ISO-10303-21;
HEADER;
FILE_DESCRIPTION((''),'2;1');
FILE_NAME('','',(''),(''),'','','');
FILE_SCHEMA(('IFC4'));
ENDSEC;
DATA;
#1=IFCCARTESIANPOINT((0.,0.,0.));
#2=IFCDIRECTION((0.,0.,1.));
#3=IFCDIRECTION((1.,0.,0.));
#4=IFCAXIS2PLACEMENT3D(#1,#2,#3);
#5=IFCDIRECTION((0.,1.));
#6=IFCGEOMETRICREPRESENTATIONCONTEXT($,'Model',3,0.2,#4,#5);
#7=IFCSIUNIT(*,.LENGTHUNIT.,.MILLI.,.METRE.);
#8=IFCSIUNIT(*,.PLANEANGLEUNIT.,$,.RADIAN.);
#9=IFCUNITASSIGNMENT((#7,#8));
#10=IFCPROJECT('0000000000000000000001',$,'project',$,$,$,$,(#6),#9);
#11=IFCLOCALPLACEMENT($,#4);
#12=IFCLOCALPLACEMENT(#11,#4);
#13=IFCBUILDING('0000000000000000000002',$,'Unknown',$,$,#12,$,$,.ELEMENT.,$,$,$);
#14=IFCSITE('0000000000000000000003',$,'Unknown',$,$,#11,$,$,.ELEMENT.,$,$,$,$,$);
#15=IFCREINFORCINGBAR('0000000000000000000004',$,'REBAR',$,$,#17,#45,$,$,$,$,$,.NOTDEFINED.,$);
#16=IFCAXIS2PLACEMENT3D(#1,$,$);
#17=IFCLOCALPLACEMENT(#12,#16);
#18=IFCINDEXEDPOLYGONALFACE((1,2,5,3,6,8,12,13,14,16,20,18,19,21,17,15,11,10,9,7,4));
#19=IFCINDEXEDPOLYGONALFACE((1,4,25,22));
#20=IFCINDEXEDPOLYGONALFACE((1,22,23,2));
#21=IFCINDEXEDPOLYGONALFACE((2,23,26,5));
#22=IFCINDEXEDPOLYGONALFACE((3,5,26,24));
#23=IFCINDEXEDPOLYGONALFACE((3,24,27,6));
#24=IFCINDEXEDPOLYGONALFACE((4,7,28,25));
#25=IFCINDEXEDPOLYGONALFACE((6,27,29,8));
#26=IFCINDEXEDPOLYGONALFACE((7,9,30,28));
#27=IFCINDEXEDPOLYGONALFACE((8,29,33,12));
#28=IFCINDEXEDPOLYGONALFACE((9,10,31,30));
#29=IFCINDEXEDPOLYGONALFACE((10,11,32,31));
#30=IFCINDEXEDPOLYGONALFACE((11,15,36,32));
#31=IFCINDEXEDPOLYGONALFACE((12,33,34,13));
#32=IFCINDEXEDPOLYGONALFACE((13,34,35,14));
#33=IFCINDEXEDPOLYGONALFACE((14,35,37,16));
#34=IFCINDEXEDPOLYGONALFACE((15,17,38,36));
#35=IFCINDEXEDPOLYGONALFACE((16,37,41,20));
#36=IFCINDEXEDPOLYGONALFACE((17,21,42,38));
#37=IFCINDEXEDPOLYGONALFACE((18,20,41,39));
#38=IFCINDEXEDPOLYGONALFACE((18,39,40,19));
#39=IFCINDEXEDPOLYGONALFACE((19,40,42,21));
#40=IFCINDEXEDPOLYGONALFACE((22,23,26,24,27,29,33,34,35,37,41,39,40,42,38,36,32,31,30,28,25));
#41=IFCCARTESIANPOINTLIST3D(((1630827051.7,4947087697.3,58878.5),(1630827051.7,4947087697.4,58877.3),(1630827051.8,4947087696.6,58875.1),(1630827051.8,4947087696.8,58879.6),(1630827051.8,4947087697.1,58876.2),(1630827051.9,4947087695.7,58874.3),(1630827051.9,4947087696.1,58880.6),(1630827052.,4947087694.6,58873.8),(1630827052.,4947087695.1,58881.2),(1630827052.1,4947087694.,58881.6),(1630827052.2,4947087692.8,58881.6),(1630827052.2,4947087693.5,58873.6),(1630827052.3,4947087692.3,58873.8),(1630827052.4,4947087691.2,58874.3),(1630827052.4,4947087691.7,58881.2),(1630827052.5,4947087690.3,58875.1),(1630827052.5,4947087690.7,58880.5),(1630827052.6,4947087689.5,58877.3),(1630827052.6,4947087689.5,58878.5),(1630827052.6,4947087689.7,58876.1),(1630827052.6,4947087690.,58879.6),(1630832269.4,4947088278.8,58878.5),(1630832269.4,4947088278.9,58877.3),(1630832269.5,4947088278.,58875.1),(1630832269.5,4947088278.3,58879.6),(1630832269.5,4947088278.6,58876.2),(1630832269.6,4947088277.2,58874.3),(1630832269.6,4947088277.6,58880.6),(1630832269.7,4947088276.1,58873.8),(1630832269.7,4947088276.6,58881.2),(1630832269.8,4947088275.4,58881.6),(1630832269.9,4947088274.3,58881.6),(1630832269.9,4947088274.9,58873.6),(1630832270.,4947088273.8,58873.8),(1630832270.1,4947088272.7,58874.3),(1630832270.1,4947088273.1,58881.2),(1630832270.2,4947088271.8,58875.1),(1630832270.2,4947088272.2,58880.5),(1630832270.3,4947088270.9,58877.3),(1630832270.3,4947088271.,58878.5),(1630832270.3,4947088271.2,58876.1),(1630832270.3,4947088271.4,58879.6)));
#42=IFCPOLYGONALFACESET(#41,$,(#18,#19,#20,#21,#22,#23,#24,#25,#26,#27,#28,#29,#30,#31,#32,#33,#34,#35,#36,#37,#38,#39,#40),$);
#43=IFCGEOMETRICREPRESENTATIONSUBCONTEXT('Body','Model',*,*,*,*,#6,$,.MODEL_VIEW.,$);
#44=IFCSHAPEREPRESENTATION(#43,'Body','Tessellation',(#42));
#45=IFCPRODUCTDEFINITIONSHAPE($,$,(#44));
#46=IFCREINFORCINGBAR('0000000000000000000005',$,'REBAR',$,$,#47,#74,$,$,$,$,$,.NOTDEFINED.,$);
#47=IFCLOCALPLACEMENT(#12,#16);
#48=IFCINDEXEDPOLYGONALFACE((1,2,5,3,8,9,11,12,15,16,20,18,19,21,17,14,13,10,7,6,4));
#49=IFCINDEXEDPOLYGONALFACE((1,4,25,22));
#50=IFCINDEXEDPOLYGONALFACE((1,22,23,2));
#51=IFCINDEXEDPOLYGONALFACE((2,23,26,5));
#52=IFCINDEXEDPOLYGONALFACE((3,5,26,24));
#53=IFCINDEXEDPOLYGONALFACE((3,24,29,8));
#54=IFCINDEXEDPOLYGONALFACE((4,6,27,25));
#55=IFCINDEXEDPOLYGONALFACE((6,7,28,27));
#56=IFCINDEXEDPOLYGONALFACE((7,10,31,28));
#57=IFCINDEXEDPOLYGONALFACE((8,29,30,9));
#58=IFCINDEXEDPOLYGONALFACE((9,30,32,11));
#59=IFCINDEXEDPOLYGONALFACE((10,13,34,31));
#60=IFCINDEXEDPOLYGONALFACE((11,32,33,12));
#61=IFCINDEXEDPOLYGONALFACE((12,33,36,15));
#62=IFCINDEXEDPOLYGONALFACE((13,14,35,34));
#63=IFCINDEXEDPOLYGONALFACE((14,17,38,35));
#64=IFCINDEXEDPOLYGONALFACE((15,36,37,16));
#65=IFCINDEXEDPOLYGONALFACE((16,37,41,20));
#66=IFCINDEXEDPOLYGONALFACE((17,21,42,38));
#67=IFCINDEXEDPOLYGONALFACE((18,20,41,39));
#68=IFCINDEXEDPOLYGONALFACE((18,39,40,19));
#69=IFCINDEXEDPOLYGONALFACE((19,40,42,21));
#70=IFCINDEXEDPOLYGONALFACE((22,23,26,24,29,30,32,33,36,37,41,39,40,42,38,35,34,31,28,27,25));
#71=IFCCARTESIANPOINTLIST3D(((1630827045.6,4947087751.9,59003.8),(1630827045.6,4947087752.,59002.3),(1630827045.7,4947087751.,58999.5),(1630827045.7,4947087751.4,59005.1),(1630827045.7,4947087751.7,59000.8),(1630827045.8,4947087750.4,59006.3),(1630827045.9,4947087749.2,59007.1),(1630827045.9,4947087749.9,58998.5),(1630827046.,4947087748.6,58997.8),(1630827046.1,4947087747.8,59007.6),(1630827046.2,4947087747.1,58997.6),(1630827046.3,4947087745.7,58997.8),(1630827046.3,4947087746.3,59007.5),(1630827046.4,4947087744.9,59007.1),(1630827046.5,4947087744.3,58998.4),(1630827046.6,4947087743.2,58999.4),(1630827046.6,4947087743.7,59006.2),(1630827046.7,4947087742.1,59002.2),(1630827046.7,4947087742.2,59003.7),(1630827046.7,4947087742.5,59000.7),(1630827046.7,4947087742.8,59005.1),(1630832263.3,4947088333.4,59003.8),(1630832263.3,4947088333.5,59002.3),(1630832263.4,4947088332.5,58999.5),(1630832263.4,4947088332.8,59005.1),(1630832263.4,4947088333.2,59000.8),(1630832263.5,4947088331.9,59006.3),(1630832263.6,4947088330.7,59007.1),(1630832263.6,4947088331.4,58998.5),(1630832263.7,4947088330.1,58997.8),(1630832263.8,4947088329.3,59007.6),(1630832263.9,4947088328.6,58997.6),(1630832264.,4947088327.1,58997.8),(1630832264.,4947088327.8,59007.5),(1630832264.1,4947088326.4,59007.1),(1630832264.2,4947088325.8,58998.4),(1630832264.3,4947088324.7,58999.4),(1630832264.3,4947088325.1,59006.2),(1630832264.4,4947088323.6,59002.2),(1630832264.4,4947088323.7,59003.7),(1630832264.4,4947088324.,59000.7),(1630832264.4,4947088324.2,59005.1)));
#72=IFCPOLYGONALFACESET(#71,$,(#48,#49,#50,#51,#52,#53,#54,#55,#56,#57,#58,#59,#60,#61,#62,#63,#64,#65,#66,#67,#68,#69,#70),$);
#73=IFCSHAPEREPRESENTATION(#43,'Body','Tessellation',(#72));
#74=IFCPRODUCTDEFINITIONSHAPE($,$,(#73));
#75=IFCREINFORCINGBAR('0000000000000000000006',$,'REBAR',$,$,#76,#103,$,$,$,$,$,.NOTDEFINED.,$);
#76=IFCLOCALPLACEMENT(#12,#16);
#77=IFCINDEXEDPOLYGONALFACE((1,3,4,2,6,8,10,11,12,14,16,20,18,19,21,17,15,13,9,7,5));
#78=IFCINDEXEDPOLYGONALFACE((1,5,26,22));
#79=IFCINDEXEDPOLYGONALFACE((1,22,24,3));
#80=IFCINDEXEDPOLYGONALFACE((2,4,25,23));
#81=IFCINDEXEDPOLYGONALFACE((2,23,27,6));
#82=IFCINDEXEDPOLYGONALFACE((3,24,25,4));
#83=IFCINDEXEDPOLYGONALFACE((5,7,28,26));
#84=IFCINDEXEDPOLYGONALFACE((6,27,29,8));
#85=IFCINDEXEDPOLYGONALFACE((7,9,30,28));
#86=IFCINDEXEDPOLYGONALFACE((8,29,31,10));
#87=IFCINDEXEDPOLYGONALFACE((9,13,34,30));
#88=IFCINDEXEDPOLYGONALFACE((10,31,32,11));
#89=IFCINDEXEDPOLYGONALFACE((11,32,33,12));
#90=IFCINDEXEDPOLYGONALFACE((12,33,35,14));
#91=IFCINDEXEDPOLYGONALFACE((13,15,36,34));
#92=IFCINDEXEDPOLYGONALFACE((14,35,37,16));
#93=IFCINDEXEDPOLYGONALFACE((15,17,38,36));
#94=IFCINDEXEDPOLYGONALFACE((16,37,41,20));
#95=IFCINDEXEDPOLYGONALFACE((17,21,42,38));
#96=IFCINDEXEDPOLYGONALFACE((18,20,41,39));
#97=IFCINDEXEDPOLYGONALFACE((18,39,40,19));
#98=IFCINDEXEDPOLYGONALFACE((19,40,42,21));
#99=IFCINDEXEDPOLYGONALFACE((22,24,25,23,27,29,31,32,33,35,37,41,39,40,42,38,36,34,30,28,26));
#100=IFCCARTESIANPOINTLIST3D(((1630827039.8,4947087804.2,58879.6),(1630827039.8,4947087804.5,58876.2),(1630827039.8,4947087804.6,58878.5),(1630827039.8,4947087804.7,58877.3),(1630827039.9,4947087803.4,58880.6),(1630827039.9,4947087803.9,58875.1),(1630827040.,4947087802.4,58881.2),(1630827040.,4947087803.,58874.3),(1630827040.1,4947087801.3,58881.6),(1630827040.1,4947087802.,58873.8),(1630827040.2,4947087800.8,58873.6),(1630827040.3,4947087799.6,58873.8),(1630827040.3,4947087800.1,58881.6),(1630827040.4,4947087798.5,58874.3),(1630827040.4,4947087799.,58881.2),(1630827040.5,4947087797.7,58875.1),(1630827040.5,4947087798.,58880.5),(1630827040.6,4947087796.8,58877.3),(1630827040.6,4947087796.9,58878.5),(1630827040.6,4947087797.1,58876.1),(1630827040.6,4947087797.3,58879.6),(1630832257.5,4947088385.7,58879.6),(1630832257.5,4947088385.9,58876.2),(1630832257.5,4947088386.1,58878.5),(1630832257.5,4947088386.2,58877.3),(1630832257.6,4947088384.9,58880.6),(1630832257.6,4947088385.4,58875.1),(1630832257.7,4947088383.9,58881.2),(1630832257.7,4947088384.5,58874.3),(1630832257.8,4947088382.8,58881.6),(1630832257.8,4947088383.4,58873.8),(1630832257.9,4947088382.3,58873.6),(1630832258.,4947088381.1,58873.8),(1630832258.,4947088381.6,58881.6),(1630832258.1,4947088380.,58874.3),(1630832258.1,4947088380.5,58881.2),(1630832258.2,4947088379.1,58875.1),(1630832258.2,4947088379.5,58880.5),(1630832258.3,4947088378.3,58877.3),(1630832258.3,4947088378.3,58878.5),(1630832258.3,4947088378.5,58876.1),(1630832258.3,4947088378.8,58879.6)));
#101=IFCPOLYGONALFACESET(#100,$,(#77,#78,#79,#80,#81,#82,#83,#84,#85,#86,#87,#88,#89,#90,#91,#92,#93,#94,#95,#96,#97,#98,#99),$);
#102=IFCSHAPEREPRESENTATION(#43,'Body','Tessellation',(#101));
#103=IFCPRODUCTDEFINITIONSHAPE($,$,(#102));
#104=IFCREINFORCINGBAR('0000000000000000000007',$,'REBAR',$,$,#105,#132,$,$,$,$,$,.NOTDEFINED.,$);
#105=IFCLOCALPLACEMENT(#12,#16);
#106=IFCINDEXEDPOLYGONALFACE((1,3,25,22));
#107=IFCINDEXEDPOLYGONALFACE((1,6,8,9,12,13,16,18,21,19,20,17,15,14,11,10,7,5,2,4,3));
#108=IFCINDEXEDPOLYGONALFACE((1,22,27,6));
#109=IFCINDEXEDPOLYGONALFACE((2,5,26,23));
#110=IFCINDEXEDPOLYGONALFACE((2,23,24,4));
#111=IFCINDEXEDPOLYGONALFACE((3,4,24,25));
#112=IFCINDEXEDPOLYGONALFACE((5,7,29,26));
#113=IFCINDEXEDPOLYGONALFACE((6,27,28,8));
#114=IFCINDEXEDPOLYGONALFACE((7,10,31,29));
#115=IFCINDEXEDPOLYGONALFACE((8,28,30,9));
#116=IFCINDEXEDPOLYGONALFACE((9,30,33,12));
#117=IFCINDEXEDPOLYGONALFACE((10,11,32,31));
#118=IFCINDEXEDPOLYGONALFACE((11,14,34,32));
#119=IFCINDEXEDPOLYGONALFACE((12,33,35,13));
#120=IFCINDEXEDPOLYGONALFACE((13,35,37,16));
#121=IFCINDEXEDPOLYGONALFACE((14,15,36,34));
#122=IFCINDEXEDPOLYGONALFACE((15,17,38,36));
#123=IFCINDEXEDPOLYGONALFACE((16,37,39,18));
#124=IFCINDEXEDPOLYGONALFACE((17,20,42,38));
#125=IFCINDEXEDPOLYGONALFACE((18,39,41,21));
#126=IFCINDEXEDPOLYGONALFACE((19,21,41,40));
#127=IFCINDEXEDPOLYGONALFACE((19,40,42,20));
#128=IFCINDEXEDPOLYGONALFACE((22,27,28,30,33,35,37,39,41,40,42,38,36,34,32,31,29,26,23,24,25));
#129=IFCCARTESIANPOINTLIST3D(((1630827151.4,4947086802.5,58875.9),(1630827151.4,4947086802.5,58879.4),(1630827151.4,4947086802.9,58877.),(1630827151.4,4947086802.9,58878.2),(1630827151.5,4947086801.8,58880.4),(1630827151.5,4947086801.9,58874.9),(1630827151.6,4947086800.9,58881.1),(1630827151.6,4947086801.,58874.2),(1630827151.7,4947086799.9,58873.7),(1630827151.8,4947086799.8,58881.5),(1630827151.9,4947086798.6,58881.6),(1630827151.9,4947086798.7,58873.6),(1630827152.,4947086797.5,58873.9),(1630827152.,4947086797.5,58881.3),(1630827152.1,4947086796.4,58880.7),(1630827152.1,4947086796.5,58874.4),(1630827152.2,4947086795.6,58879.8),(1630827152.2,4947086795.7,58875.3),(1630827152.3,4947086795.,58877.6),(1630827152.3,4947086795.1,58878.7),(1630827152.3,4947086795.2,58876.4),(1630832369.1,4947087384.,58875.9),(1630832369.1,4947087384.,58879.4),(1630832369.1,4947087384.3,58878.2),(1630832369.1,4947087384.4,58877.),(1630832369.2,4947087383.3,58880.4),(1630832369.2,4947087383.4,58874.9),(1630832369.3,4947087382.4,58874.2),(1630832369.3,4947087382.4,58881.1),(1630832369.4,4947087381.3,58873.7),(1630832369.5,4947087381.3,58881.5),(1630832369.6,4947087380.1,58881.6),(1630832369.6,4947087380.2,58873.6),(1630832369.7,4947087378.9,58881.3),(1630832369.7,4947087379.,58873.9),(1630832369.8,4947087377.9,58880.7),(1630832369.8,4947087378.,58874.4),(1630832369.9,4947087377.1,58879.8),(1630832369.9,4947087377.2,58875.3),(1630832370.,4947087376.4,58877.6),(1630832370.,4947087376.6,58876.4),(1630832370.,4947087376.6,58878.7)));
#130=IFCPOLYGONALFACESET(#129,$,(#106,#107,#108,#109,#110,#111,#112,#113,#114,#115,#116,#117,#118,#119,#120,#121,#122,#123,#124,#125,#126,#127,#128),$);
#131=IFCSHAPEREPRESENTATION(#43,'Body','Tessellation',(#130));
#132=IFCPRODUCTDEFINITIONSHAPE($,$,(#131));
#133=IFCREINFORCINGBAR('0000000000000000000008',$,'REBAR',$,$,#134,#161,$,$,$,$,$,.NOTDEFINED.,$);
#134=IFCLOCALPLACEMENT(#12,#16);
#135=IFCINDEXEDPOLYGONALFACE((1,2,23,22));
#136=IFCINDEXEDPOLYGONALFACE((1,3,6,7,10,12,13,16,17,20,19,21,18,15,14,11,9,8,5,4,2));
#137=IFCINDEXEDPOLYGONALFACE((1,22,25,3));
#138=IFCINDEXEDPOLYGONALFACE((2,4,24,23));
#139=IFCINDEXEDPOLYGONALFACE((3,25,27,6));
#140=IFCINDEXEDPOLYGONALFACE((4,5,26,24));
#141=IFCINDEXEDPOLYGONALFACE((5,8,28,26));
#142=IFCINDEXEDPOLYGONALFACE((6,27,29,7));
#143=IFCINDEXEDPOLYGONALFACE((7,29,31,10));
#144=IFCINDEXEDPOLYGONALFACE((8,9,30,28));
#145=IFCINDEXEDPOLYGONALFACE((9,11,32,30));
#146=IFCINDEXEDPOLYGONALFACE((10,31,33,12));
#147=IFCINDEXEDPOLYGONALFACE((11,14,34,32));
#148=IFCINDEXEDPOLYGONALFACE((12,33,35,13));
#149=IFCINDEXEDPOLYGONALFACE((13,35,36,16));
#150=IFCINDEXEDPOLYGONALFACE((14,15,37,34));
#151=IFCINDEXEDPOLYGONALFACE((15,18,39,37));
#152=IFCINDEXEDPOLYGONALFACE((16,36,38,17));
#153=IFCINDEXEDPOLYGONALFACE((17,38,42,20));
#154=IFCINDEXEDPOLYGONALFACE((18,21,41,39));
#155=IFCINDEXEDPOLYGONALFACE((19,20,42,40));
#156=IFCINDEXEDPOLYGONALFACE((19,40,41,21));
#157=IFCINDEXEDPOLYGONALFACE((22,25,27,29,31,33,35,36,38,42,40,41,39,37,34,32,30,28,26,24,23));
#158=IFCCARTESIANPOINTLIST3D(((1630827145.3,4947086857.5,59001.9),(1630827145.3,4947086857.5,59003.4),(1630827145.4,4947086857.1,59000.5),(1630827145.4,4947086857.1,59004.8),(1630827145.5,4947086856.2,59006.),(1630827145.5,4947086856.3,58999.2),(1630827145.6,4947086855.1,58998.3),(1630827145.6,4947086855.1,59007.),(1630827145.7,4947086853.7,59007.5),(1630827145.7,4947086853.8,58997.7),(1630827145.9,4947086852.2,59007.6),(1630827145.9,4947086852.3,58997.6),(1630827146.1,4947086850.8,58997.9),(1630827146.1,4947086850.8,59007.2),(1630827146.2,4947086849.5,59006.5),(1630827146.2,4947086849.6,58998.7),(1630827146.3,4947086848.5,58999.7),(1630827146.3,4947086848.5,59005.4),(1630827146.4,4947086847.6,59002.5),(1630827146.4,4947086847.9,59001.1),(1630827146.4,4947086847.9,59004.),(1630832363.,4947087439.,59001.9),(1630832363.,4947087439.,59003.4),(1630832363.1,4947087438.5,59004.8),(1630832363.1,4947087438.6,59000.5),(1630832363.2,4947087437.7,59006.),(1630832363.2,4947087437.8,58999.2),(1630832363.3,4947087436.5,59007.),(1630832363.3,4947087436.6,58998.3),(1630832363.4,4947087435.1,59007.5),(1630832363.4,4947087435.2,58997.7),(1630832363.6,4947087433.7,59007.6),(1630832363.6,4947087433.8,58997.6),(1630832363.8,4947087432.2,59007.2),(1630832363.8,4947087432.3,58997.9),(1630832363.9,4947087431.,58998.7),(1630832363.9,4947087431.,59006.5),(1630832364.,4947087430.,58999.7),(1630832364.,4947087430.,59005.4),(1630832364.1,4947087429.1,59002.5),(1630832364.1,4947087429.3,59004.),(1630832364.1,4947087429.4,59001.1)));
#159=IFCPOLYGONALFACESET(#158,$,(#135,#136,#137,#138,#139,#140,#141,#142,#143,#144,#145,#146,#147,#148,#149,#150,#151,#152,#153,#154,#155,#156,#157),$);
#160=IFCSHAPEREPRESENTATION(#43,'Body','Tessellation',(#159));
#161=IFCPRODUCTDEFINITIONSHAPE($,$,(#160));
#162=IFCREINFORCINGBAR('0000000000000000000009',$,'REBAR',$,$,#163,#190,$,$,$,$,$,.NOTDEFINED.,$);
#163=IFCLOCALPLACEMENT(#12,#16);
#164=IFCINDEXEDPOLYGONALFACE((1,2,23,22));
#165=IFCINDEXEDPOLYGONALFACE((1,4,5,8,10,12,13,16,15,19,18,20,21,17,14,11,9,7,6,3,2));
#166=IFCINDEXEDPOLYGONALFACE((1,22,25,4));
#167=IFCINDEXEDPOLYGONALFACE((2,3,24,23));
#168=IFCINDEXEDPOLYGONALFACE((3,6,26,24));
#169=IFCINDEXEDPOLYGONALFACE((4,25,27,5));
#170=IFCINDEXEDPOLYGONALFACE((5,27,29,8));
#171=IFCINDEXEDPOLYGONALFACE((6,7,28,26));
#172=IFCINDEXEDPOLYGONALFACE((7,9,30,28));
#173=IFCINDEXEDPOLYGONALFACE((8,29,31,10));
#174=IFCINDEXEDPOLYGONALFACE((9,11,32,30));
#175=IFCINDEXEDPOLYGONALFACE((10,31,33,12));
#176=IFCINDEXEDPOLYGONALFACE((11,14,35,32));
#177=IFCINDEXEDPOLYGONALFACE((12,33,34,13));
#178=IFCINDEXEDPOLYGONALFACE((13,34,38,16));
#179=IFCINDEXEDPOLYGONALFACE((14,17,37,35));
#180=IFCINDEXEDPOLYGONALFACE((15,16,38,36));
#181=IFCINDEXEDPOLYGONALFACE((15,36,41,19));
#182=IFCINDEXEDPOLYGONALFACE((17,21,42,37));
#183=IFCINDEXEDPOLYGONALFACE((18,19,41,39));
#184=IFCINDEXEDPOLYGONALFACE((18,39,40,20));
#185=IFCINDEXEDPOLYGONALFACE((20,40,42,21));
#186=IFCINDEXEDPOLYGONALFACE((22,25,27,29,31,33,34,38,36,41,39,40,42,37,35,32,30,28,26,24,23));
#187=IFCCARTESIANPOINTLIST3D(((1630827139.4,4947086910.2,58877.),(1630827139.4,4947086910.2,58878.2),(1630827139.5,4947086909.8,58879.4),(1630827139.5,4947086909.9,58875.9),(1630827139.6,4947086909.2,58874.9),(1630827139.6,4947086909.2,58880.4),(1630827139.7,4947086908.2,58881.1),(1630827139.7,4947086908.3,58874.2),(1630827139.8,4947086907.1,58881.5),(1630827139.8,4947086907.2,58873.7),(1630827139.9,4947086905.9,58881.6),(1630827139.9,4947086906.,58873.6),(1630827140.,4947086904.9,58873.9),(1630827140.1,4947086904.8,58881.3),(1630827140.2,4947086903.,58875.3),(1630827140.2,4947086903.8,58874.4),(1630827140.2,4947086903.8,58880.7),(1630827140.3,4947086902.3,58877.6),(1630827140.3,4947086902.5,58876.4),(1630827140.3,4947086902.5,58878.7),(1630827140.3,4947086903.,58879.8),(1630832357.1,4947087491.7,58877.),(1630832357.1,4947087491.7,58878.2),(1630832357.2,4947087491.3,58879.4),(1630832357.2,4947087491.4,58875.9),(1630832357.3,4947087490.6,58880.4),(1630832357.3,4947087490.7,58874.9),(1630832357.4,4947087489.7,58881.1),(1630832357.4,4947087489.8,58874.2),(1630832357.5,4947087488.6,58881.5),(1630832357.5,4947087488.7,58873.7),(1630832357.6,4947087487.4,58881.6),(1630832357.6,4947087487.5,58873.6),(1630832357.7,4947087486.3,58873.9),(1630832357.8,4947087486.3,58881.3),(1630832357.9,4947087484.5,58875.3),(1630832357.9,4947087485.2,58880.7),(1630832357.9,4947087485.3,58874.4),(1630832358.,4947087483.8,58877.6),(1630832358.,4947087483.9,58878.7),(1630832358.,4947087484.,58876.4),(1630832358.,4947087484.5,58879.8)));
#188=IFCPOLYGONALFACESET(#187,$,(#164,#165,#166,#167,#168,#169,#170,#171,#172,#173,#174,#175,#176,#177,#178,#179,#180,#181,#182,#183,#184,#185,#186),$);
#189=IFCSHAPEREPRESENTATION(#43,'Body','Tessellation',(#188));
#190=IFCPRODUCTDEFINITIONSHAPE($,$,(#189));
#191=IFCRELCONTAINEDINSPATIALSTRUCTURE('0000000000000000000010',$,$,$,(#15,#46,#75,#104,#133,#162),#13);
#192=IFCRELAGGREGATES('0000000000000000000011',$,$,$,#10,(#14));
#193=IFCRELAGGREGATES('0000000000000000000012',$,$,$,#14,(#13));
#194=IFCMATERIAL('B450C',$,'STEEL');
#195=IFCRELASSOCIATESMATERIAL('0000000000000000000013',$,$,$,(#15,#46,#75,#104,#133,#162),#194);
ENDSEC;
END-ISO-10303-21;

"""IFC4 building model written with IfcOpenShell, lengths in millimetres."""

from ifc_helpers import new_model, entity, si_unit, direction, frame, origin_with_axes, place, context, subcontext, project, spatial, material, element, save


model = new_model("IFC4")

# Units and contexts
model_context = context("Model", 3, precision=0.2, world=origin_with_axes(), true_north=direction((0.0, 1.0)))
body_context = subcontext(model_context, "Body", "Model", "MODEL_VIEW")
ifc_project = project(units=[si_unit("LENGTHUNIT", "METRE", prefix="MILLI"), si_unit("PLANEANGLEUNIT", "RADIAN")], contexts=[model_context])

# Site, building
site_placement = place(None, origin_with_axes())
site = spatial("IfcSite", under=ifc_project, at=site_placement, Name="Unknown", CompositionType="ELEMENT")
building_placement = place(site_placement, origin_with_axes())
building = spatial("IfcBuilding", under=site, at=building_placement, Name="Unknown", CompositionType="ELEMENT")

# Reinforcing bars
ifc_material = material(Name="B450C", Category="STEEL")
reinforcing_bar_1_placement = place(building_placement, frame((1630832269.9, 4947088274.9, 58877.6), z_axis=(0.007106, -0.063762, -0.99794), x_axis=(-0.993847, -0.110757, 0.0)))
element("IfcReinforcingBar", 1, at=reinforcing_bar_1_placement, inside=building, material=ifc_material, Name="REBAR", PredefinedType="NOTDEFINED", context=body_context, shape_type="AdvancedSweptSolid", body=[
    entity("IfcSweptDiskSolid", entity("IfcIndexedPolyCurve", entity("IfcCartesianPointList3D", [[0.0, 0.0, 0.0], [5250.0, 0.0, 0.0]]), [entity("IfcLineIndex", [1, 2])]), 4.0),
])
reinforcing_bar_2_placement = place(building_placement, frame((1630832263.9, 4947088328.6, 59002.6), z_axis=(0.007106, -0.063762, -0.99794), x_axis=(-0.993847, -0.110757, 0.0)))
element("IfcReinforcingBar", 2, at=reinforcing_bar_2_placement, inside=building, material=ifc_material, Name="REBAR", PredefinedType="NOTDEFINED", context=body_context, shape_type="AdvancedSweptSolid", body=[
    entity("IfcSweptDiskSolid", entity("IfcIndexedPolyCurve", entity("IfcCartesianPointList3D", [[0.0, 0.0, 0.0], [5250.0, 0.0, 0.0]]), [entity("IfcLineIndex", [1, 2])]), 5.0),
])
reinforcing_bar_3_placement = place(building_placement, frame((1630832257.9, 4947088382.2, 58877.6), z_axis=(0.007106, -0.063762, -0.99794), x_axis=(-0.993847, -0.110757, 0.0)))
element("IfcReinforcingBar", 3, at=reinforcing_bar_3_placement, inside=building, material=ifc_material, Name="REBAR", PredefinedType="NOTDEFINED", context=body_context, shape_type="AdvancedSweptSolid", body=[
    entity("IfcSweptDiskSolid", entity("IfcIndexedPolyCurve", entity("IfcCartesianPointList3D", [[0.0, 0.0, 0.0], [5250.0, 0.0, 0.0]]), [entity("IfcLineIndex", [1, 2])]), 4.0),
])
reinforcing_bar_4_placement = place(building_placement, frame((1630832369.5, 4947087380.4, 58877.6), z_axis=(0.007106, -0.063762, -0.99794), x_axis=(-0.993847, -0.110757, 0.0)))
element("IfcReinforcingBar", 4, at=reinforcing_bar_4_placement, inside=building, material=ifc_material, Name="REBAR", PredefinedType="NOTDEFINED", context=body_context, shape_type="AdvancedSweptSolid", body=[
    entity("IfcSweptDiskSolid", entity("IfcIndexedPolyCurve", entity("IfcCartesianPointList3D", [[0.0, 0.0, 0.0], [5250.0, 0.0, 0.0]]), [entity("IfcLineIndex", [1, 2])]), 4.0),
])
reinforcing_bar_5_placement = place(building_placement, frame((1630832363.6, 4947087434.1, 59002.6), z_axis=(0.007106, -0.063762, -0.99794), x_axis=(-0.993847, -0.110757, 0.0)))
element("IfcReinforcingBar", 5, at=reinforcing_bar_5_placement, inside=building, material=ifc_material, Name="REBAR", PredefinedType="NOTDEFINED", context=body_context, shape_type="AdvancedSweptSolid", body=[
    entity("IfcSweptDiskSolid", entity("IfcIndexedPolyCurve", entity("IfcCartesianPointList3D", [[0.0, 0.0, 0.0], [5250.0, 0.0, 0.0]]), [entity("IfcLineIndex", [1, 2])]), 5.0),
])
reinforcing_bar_6_placement = place(building_placement, frame((1630832357.6, 4947087487.8, 58877.6), z_axis=(0.007106, -0.063762, -0.99794), x_axis=(-0.993847, -0.110757, 0.0)))
element("IfcReinforcingBar", 6, at=reinforcing_bar_6_placement, inside=building, material=ifc_material, Name="REBAR", PredefinedType="NOTDEFINED", context=body_context, shape_type="AdvancedSweptSolid", body=[
    entity("IfcSweptDiskSolid", entity("IfcIndexedPolyCurve", entity("IfcCartesianPointList3D", [[0.0, 0.0, 0.0], [5250.0, 0.0, 0.0]]), [entity("IfcLineIndex", [1, 2])]), 4.0),
])

save(model, "model.ifc")
